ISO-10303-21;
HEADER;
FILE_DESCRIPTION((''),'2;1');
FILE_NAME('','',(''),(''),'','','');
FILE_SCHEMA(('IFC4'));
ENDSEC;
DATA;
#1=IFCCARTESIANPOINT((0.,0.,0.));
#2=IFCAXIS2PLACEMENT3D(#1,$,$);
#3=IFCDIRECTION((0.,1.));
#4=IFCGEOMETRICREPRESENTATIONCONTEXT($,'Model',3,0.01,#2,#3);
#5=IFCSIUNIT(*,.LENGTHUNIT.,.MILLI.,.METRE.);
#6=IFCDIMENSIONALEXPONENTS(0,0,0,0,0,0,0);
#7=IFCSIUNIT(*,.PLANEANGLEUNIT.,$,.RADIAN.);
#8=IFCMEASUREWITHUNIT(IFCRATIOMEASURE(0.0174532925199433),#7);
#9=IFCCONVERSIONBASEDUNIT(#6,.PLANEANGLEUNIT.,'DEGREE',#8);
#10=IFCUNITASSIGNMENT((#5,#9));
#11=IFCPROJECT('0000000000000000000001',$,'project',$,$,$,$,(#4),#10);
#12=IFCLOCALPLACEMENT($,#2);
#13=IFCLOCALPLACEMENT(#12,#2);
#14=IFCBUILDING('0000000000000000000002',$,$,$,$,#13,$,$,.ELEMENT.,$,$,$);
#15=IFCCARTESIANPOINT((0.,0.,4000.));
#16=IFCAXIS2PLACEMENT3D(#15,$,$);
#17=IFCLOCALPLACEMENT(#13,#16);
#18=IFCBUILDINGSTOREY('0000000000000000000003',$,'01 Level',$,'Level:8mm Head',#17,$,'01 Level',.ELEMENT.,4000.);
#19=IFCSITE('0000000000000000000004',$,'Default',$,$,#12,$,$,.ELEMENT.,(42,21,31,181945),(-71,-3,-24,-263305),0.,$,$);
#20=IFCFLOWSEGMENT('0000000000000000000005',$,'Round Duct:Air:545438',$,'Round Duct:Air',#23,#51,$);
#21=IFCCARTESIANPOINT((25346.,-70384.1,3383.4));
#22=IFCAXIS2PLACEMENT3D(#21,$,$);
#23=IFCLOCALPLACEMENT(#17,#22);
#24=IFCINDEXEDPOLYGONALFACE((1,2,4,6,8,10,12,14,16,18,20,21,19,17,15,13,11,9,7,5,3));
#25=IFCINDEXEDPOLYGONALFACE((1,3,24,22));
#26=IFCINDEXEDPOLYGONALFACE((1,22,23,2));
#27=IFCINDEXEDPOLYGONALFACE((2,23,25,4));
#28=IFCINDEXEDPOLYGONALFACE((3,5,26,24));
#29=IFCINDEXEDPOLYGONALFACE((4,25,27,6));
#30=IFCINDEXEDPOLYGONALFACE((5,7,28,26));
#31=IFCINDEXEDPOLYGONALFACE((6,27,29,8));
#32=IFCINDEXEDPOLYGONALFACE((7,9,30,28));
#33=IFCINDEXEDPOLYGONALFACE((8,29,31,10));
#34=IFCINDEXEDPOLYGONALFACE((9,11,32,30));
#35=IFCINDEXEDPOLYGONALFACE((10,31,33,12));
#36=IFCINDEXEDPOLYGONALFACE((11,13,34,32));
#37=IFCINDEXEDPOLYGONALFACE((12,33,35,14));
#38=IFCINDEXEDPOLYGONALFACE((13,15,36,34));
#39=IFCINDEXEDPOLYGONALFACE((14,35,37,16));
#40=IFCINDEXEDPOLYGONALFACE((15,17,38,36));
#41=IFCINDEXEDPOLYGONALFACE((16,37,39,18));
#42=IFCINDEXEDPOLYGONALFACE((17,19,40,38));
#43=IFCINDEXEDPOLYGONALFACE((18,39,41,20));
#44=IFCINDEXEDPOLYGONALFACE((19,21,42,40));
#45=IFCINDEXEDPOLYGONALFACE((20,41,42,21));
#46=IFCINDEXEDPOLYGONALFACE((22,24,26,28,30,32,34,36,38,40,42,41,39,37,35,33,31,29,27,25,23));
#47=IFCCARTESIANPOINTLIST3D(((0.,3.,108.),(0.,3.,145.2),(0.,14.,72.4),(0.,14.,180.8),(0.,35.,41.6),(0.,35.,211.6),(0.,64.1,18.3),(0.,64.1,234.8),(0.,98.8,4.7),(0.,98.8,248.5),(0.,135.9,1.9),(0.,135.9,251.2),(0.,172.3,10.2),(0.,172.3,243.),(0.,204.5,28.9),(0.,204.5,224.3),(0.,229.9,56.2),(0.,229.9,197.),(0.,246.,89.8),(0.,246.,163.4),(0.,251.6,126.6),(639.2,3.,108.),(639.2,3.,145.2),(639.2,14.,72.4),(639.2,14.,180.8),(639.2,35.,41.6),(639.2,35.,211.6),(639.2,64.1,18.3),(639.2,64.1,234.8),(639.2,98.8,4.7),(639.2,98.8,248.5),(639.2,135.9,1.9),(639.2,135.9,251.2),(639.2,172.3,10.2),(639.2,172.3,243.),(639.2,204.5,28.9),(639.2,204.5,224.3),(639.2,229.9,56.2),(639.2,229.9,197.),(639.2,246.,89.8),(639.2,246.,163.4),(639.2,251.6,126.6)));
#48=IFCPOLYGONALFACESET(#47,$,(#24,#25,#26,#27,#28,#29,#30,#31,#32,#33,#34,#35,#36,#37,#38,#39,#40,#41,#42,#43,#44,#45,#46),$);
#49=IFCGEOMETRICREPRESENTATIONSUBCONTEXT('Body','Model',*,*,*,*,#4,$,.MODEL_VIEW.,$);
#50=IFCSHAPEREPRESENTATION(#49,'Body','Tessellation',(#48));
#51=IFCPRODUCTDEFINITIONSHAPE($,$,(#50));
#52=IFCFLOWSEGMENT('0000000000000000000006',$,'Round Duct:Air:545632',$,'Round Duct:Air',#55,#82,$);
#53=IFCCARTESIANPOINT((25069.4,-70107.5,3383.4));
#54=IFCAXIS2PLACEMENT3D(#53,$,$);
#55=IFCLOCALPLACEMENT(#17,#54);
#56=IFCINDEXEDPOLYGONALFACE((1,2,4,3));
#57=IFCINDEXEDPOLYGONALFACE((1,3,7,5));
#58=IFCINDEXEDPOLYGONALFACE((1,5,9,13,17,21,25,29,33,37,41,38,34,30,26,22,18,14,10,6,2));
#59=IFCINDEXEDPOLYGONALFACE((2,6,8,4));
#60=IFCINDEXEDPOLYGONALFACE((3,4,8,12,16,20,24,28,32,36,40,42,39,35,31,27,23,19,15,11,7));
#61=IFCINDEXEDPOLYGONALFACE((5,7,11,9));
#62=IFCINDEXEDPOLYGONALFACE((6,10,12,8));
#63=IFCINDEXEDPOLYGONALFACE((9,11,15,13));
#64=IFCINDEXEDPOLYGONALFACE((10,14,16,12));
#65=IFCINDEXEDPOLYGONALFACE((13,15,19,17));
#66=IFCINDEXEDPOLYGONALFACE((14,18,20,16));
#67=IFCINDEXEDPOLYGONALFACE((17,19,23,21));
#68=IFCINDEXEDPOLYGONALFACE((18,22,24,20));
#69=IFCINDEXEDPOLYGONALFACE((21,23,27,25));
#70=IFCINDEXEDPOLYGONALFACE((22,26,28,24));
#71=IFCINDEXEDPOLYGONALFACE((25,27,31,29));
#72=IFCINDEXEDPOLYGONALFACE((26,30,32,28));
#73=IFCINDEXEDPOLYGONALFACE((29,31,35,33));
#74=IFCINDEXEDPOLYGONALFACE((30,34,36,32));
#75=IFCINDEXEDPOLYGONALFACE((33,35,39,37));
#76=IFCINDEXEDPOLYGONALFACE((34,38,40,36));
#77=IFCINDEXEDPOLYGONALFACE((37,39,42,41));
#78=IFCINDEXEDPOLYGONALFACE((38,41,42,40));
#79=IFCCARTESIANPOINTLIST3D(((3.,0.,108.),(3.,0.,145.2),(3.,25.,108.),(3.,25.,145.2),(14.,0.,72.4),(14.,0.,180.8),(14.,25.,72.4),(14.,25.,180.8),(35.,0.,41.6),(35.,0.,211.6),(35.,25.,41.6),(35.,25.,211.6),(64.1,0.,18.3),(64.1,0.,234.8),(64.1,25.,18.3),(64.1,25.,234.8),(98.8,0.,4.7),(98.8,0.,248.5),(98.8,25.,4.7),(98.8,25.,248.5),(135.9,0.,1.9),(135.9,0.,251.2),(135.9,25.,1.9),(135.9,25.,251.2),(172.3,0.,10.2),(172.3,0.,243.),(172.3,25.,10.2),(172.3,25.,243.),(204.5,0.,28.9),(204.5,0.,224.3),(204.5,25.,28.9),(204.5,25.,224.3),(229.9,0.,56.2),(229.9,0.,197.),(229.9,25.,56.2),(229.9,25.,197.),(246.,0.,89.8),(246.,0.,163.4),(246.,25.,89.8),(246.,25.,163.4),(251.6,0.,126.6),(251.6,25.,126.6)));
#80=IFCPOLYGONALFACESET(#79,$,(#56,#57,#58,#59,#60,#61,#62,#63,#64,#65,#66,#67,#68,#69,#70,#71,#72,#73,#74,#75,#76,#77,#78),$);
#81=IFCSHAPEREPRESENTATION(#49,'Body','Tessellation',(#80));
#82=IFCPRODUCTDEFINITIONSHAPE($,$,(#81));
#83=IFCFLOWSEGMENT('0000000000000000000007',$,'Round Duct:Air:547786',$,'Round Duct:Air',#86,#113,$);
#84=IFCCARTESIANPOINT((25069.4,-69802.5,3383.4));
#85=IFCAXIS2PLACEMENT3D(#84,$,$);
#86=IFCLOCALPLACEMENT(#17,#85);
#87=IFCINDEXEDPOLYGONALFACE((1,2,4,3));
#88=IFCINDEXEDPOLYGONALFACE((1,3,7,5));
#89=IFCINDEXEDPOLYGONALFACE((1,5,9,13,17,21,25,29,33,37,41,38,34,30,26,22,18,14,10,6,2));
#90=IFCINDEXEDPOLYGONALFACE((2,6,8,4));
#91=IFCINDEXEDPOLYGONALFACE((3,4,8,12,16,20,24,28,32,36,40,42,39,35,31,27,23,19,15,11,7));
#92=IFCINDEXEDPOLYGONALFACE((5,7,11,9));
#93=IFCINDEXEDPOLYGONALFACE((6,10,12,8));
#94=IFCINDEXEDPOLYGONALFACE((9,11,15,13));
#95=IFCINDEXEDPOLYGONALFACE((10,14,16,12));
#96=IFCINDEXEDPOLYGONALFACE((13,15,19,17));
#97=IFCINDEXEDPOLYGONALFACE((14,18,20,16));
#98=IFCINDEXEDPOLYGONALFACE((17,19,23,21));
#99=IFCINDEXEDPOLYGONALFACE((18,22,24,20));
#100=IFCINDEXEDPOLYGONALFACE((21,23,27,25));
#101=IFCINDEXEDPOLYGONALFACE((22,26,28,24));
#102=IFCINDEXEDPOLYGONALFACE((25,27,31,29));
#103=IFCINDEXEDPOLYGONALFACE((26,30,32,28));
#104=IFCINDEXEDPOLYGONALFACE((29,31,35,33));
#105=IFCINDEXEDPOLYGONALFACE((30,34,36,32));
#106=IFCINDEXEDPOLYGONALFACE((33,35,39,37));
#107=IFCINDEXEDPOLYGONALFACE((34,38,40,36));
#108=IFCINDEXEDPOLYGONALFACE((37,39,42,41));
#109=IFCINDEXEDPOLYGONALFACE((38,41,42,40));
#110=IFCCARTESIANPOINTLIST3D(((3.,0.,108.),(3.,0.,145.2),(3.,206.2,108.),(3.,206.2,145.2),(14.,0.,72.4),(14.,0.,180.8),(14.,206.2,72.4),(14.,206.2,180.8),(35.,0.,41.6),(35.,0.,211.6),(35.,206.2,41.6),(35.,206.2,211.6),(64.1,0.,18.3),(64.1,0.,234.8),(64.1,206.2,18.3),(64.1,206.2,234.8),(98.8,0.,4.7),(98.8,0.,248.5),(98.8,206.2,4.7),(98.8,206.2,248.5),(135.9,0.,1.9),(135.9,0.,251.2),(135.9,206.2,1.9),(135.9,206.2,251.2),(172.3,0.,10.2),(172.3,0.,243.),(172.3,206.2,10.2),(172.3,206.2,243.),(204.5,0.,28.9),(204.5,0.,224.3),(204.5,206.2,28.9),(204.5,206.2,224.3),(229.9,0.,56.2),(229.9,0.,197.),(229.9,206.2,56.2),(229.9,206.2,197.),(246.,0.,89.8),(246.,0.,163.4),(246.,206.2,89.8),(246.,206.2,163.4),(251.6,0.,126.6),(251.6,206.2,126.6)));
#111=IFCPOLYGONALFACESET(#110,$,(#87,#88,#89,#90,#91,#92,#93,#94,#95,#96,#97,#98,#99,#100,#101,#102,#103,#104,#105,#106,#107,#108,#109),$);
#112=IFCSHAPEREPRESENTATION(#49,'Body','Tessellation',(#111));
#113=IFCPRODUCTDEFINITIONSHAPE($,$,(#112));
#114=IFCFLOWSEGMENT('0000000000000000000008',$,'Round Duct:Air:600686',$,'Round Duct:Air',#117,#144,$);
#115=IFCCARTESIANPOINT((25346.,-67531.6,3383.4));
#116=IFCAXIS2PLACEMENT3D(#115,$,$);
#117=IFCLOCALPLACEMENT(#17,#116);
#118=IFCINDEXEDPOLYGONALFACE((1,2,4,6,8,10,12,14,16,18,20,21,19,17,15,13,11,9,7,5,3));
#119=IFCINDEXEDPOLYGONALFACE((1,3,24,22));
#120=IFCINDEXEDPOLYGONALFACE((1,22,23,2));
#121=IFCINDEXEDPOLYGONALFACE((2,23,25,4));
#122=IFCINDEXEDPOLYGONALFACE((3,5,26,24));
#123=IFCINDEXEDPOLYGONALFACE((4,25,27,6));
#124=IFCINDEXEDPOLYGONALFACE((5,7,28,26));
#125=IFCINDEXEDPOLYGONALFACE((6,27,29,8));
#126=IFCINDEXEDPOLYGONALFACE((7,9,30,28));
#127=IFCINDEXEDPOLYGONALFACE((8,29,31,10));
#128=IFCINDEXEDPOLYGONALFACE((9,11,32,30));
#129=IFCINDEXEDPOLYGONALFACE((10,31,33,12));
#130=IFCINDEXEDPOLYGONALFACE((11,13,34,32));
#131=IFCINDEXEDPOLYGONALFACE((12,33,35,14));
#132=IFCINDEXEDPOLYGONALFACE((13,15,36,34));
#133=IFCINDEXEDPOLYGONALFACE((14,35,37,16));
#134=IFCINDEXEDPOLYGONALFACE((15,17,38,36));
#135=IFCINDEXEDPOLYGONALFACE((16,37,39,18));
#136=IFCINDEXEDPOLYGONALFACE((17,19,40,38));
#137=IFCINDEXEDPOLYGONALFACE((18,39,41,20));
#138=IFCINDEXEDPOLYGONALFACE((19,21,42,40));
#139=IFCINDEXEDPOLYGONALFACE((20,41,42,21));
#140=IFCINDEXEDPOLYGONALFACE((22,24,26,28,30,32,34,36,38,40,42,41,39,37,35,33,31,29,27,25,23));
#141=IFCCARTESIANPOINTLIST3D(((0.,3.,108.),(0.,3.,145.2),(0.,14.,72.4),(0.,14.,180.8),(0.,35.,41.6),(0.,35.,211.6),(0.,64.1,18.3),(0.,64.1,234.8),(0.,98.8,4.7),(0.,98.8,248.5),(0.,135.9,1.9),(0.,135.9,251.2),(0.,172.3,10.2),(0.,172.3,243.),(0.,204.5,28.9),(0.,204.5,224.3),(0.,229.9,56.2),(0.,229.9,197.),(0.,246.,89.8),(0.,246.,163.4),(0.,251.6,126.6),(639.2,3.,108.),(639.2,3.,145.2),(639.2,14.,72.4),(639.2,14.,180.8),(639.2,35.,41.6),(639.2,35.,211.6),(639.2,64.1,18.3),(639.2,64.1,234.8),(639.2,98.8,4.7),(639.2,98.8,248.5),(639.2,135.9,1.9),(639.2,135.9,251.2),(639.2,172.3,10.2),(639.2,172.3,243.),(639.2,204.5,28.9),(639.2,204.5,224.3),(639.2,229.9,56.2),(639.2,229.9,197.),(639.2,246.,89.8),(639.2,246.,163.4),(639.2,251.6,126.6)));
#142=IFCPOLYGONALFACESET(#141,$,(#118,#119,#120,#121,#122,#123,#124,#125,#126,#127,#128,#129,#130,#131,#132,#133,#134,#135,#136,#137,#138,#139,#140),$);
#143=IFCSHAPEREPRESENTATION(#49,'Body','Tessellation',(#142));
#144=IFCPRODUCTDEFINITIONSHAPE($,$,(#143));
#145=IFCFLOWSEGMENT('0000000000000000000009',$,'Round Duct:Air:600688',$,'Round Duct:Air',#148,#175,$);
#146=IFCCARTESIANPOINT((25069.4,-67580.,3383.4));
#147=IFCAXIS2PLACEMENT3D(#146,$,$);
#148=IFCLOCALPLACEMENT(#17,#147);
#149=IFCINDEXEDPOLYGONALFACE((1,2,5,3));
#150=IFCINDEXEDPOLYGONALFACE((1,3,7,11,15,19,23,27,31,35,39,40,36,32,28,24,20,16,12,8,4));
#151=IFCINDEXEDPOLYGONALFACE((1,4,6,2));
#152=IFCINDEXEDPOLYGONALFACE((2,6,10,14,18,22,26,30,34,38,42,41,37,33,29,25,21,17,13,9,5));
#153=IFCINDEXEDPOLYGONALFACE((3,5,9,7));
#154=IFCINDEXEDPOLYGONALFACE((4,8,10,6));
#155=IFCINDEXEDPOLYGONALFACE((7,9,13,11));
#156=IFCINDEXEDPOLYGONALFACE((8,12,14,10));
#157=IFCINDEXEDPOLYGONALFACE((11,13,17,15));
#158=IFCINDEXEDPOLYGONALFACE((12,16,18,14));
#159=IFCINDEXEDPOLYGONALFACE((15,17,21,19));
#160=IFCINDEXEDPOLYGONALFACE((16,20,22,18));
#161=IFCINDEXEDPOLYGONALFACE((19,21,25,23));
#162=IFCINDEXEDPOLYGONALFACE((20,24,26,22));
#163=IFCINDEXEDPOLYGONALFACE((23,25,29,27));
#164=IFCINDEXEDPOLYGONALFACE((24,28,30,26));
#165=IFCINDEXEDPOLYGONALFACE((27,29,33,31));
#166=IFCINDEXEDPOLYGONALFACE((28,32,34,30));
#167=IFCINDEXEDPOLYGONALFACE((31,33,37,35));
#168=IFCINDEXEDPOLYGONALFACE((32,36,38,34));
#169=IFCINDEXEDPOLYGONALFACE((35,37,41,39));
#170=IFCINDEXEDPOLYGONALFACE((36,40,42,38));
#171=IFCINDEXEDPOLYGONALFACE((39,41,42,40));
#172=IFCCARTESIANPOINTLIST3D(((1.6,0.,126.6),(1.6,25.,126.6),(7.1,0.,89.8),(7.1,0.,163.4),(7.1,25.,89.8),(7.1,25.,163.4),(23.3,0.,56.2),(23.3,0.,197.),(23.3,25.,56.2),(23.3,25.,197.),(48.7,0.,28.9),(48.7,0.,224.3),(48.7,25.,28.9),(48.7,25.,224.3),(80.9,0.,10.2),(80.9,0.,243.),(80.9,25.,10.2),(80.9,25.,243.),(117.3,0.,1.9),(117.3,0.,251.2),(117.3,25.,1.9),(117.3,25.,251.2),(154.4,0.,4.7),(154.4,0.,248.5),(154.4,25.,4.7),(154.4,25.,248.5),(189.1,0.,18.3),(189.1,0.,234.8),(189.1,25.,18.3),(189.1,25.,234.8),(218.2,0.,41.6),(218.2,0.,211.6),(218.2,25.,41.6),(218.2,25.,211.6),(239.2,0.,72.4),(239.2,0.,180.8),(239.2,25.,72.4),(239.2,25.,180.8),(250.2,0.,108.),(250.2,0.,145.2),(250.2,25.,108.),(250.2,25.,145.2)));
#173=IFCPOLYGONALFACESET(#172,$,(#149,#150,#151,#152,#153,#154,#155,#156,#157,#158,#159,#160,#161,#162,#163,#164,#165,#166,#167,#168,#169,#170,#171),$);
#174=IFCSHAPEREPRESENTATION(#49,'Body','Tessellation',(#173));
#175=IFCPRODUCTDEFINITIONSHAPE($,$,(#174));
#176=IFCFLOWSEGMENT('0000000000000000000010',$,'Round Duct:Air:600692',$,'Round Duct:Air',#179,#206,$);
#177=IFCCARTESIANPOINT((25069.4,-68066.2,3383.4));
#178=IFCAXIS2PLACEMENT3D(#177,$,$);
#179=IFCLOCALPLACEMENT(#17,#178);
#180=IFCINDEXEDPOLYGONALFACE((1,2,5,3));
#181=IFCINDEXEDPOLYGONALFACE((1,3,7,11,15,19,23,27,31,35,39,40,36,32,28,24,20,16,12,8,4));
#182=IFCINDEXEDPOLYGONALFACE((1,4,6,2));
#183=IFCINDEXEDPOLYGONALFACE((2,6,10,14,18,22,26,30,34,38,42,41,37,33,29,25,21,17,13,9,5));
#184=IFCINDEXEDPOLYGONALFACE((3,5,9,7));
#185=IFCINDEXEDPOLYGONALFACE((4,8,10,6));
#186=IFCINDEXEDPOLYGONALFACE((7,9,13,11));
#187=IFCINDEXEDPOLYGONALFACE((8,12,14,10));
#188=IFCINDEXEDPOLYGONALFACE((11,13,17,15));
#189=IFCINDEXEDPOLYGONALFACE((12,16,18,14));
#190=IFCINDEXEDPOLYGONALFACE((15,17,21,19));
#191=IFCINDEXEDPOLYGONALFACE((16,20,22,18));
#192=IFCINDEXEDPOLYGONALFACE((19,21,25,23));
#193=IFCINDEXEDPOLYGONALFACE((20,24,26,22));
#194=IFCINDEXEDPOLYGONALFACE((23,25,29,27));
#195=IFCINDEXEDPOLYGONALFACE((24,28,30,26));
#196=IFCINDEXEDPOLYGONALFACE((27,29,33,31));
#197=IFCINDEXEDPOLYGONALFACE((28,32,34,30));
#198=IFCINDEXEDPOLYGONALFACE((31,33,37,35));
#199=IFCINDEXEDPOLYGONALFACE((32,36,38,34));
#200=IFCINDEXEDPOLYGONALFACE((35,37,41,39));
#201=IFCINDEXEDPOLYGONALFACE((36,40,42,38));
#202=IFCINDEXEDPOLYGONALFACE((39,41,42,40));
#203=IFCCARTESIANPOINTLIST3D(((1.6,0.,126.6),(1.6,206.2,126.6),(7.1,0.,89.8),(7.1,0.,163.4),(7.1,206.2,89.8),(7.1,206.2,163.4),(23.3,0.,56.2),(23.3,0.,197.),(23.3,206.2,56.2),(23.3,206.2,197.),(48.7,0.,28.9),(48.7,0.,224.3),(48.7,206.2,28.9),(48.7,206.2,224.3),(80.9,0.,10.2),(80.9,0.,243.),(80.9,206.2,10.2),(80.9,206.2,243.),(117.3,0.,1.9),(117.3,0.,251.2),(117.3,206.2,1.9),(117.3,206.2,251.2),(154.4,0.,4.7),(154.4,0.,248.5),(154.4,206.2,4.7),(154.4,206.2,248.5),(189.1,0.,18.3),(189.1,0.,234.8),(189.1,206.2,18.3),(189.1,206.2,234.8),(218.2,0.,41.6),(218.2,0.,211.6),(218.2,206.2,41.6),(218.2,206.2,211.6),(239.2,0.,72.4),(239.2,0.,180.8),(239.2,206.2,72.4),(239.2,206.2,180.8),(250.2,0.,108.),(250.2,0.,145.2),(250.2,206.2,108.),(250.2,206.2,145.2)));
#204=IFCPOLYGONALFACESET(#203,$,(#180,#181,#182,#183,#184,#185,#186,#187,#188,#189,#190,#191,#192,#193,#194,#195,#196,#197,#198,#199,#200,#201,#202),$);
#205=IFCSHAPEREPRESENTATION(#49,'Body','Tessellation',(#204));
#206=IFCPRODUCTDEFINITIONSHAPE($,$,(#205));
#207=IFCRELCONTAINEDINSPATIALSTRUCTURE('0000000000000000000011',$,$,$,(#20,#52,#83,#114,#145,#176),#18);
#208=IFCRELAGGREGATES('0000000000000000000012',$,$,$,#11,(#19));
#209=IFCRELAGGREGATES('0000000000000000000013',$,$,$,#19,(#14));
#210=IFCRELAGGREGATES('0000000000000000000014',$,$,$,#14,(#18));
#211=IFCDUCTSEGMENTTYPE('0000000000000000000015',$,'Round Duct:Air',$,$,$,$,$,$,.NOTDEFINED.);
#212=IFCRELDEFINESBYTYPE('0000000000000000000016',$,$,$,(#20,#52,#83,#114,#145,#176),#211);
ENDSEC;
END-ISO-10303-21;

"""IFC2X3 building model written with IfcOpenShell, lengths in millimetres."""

from ifc_helpers import new_model, entity, si_unit, converted_unit, direction, frame, origin, origin_2d_with_axis, place, context, subcontext, project, spatial, circle, extrude, type_object, element, save


model = new_model("IFC2X3")

# Units and contexts
model_context = context("Model", 3, precision=0.01, world=origin(), true_north=direction((0.0, 1.0)))
body_context = subcontext(model_context, "Body", "Model", "MODEL_VIEW")
ifc_project = project(units=[si_unit("LENGTHUNIT", "METRE", prefix="MILLI"), converted_unit("PLANEANGLEUNIT", "DEGREE", entity("IfcRatioMeasure", 0.0174532925199433), si_unit("PLANEANGLEUNIT", "RADIAN"), dimensions=[0, 0, 0, 0, 0, 0, 0])], contexts=[model_context])

# Site, building, storey
site_placement = place(None, origin())
site = spatial("IfcSite", under=ifc_project, at=site_placement, Name="Default", CompositionType="ELEMENT", RefLatitude=(42, 21, 31, 181945), RefLongitude=(-71, -3, -24, -263305), RefElevation=0.0)
building_placement = place(site_placement, origin())
building = spatial("IfcBuilding", under=site, at=building_placement, CompositionType="ELEMENT")
storey_placement = place(building_placement, frame((0.0, 0.0, 4000.0)))
storey = spatial("IfcBuildingStorey", under=building, at=storey_placement, Name="01 Level", ObjectType="Level:8mm Head", LongName="01 Level", CompositionType="ELEMENT", Elevation=4000.0)

# Flow segments
duct_segment_type_1 = type_object("IfcDuctSegmentType", Name="Round Duct:Air", PredefinedType="NOTDEFINED")
flow_segment_1_placement = place(storey_placement, frame((25346.0, -70384.1, 3383.4)))
element("IfcFlowSegment", 1, at=flow_segment_1_placement, inside=storey, type_object=duct_segment_type_1, Name="Round Duct:Air:545438", ObjectType="Round Duct:Air", context=body_context, shape_type="SweptSolid", body=[
    extrude(circle(Radius=125.0, at=origin_2d_with_axis()), frame((0.0, 126.6, 126.6), z_axis=(1.0, 0.0, 0.0), x_axis=(0.0, 1.0, 0.0)), (0.0, 0.0, 1.0), 639.2),
])
flow_segment_2_placement = place(storey_placement, frame((25069.4, -70107.5, 3383.4)))
element("IfcFlowSegment", 2, at=flow_segment_2_placement, inside=storey, type_object=duct_segment_type_1, Name="Round Duct:Air:545632", ObjectType="Round Duct:Air", context=body_context, shape_type="SweptSolid", body=[
    extrude(circle(Radius=125.0, at=origin_2d_with_axis()), frame((126.6, 0.0, 126.6), z_axis=(0.0, 1.0, 0.0), x_axis=(1.0, 0.0, 0.0)), (0.0, 0.0, 1.0), 25.0),
])
flow_segment_3_placement = place(storey_placement, frame((25069.4, -69802.5, 3383.4)))
element("IfcFlowSegment", 3, at=flow_segment_3_placement, inside=storey, type_object=duct_segment_type_1, Name="Round Duct:Air:547786", ObjectType="Round Duct:Air", context=body_context, shape_type="SweptSolid", body=[
    extrude(circle(Radius=125.0, at=origin_2d_with_axis()), frame((126.6, 0.0, 126.6), z_axis=(0.0, 1.0, 0.0), x_axis=(1.0, 0.0, 0.0)), (0.0, 0.0, 1.0), 206.2),
])
flow_segment_4_placement = place(storey_placement, frame((25346.0, -67531.6, 3383.4)))
element("IfcFlowSegment", 4, at=flow_segment_4_placement, inside=storey, type_object=duct_segment_type_1, Name="Round Duct:Air:600686", ObjectType="Round Duct:Air", context=body_context, shape_type="SweptSolid", body=[
    extrude(circle(Radius=125.0, at=origin_2d_with_axis()), frame((0.0, 126.6, 126.6), z_axis=(1.0, 0.0, 0.0), x_axis=(0.0, 1.0, 0.0)), (0.0, 0.0, 1.0), 639.2),
])
flow_segment_5_placement = place(storey_placement, frame((25069.4, -67580.0, 3383.4)))
element("IfcFlowSegment", 5, at=flow_segment_5_placement, inside=storey, type_object=duct_segment_type_1, Name="Round Duct:Air:600688", ObjectType="Round Duct:Air", context=body_context, shape_type="SweptSolid", body=[
    extrude(circle(Radius=125.0, at=origin_2d_with_axis()), frame((126.6, 0.0, 126.6), z_axis=(0.0, 1.0, 0.0), x_axis=(-1.0, 0.0, 0.0)), (0.0, 0.0, 1.0), 25.0),
])
flow_segment_6_placement = place(storey_placement, frame((25069.4, -68066.2, 3383.4)))
element("IfcFlowSegment", 6, at=flow_segment_6_placement, inside=storey, type_object=duct_segment_type_1, Name="Round Duct:Air:600692", ObjectType="Round Duct:Air", context=body_context, shape_type="SweptSolid", body=[
    extrude(circle(Radius=125.0, at=origin_2d_with_axis()), frame((126.6, 0.0, 126.6), z_axis=(0.0, 1.0, 0.0), x_axis=(-1.0, 0.0, 0.0)), (0.0, 0.0, 1.0), 206.2),
])

save(model, "model.ifc")
